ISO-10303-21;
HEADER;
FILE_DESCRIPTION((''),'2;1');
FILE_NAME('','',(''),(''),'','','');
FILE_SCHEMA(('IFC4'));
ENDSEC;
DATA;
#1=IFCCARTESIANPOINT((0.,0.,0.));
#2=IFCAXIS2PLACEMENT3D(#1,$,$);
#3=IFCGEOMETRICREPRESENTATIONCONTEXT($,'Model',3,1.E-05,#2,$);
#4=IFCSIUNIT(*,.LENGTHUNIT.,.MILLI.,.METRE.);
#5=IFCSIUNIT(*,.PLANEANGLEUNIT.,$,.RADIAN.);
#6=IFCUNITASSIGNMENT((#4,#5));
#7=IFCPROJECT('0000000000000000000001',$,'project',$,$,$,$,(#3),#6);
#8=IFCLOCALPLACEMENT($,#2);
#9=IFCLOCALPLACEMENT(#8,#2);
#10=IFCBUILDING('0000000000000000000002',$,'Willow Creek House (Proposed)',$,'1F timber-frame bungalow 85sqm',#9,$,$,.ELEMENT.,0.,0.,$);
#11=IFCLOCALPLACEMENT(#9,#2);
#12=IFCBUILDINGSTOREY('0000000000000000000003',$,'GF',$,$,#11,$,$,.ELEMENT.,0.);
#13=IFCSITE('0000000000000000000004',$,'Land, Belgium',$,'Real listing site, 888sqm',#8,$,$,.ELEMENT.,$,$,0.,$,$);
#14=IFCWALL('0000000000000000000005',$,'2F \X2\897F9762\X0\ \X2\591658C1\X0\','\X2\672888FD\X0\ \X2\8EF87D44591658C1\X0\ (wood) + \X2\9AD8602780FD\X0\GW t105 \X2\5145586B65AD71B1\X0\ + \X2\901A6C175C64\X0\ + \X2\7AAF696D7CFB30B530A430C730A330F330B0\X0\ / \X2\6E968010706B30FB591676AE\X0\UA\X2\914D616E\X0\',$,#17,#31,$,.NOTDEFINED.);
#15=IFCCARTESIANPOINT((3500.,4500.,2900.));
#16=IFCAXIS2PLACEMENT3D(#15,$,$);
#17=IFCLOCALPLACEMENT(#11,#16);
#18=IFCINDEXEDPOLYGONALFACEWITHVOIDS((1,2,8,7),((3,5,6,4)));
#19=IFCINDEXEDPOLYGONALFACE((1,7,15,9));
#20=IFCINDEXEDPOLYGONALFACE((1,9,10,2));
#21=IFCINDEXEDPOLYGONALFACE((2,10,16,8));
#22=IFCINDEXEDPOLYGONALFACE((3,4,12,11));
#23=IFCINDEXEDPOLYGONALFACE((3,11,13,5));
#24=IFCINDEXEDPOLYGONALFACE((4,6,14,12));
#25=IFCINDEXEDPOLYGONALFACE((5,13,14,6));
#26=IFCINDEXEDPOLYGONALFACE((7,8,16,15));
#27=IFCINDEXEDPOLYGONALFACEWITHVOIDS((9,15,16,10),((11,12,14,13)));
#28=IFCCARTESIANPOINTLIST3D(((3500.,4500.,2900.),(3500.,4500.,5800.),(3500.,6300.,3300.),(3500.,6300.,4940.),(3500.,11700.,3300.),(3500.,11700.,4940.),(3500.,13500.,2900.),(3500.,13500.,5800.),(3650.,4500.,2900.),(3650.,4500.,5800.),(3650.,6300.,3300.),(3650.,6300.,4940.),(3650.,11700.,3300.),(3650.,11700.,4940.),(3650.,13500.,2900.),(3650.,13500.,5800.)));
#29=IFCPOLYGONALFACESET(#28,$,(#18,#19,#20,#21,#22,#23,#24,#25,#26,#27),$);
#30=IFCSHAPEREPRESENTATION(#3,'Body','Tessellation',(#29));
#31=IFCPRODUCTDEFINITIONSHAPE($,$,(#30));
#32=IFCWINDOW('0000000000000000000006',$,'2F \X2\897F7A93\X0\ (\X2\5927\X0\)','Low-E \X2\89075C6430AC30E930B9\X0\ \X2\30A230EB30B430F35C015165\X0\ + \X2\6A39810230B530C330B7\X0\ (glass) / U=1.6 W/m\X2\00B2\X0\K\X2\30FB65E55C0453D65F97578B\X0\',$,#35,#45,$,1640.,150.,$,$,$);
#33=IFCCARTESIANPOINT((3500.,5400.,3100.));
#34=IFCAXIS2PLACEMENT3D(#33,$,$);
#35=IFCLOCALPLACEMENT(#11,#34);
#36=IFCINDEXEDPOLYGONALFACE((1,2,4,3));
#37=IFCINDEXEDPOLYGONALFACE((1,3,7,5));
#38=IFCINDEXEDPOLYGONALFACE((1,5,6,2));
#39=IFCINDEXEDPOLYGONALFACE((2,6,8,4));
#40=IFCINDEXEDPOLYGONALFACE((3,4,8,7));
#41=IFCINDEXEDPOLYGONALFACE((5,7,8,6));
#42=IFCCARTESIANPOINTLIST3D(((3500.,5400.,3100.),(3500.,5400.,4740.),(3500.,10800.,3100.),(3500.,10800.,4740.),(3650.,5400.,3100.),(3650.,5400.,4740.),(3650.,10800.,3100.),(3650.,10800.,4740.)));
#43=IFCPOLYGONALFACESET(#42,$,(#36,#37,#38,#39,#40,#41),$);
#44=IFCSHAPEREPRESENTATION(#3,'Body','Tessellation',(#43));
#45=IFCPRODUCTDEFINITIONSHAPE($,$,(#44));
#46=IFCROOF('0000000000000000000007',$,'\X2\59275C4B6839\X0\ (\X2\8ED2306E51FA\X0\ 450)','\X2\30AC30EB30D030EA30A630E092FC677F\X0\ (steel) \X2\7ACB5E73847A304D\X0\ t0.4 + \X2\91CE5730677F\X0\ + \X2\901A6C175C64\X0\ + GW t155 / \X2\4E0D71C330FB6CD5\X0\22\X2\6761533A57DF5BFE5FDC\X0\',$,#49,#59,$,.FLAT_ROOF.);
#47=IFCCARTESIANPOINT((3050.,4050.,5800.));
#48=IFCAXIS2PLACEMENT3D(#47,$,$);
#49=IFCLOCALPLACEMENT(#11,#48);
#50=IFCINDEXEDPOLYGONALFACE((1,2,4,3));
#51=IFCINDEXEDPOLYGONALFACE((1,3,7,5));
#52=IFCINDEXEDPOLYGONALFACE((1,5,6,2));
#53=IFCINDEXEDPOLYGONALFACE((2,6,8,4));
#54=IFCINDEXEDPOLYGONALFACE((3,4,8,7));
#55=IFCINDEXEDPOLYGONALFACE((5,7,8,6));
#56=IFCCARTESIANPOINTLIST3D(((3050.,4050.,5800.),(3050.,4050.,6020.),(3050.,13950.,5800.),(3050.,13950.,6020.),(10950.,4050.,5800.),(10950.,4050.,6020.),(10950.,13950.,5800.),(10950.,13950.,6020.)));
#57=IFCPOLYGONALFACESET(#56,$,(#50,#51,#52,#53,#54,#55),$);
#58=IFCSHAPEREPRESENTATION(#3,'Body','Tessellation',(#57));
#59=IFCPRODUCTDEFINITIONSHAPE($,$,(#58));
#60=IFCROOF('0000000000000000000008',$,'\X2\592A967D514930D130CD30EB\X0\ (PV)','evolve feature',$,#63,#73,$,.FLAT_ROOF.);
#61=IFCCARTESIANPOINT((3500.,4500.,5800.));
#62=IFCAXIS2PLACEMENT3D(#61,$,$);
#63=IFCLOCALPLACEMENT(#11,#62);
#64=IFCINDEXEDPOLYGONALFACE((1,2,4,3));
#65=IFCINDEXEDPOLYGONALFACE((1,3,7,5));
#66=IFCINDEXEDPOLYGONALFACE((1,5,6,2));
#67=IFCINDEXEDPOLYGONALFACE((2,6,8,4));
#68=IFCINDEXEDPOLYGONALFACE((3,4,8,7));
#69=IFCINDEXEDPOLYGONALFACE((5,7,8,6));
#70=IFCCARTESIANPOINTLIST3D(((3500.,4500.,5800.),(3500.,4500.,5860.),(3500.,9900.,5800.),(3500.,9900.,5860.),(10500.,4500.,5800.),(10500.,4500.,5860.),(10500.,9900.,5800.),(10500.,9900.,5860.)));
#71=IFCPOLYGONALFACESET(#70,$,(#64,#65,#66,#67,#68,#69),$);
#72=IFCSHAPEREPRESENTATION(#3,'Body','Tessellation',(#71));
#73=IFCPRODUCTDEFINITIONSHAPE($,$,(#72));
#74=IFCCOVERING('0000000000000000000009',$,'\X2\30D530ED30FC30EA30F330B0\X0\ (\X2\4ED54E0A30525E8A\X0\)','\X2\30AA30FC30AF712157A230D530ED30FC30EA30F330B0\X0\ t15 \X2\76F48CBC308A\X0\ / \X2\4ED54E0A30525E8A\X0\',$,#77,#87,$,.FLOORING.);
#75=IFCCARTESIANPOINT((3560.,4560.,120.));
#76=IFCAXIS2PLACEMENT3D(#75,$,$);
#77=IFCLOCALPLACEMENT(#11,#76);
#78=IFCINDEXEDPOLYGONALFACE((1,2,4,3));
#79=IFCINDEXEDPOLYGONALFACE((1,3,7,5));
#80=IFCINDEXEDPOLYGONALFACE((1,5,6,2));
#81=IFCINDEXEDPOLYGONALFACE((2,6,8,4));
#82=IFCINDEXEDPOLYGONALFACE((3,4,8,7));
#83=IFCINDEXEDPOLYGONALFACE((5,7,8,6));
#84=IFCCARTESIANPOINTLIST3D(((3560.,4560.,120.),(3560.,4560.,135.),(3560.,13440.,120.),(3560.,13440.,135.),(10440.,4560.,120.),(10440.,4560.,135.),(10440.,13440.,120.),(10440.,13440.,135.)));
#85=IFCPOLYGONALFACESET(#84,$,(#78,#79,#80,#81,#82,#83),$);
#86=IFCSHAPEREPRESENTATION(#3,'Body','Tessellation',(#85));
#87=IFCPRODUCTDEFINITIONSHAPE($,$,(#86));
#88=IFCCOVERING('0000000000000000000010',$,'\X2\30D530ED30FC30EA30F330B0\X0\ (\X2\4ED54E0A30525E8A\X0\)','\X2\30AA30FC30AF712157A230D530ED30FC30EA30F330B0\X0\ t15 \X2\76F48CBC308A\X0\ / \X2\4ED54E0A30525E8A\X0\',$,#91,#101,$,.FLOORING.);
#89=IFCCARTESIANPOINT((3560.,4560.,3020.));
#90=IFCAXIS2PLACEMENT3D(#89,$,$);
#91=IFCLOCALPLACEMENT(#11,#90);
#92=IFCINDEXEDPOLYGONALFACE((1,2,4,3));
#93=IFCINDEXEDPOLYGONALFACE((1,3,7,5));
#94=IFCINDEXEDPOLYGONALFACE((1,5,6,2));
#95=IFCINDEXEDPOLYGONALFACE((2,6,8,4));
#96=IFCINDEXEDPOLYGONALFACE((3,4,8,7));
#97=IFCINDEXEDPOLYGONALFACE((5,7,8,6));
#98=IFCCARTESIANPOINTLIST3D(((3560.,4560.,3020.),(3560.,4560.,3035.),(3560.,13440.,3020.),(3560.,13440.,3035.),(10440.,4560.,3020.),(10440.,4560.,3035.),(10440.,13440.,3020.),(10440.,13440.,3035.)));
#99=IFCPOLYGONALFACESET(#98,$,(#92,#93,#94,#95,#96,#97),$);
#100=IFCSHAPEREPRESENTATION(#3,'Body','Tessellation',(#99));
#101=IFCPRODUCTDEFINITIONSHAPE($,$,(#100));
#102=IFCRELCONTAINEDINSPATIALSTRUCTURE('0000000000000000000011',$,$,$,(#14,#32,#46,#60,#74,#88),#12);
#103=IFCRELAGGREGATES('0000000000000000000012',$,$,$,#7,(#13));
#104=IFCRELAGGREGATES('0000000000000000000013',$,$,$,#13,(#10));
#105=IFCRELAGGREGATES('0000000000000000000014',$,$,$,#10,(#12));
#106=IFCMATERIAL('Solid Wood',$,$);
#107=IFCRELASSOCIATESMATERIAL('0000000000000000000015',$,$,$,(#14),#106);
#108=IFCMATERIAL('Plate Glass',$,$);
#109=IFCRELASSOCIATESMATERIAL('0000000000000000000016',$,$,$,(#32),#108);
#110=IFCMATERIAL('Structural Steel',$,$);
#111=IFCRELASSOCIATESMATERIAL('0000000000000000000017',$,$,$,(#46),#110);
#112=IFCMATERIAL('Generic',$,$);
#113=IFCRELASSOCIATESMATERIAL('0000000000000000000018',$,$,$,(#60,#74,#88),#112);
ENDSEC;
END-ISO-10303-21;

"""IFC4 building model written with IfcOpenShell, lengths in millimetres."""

from ifc_helpers import new_model, si_unit, frame, frame_2d, origin, place, context, project, spatial, rectangle, extrude, material, element, fill, save


model = new_model("IFC4")

# Units and contexts
model_context = context("Model", 3, precision=1e-05, world=origin())
ifc_project = project(units=[si_unit("LENGTHUNIT", "METRE", prefix="MILLI"), si_unit("PLANEANGLEUNIT", "RADIAN")], contexts=[model_context])

# Site, building, storey
site_placement = place(None, origin())
site = spatial("IfcSite", under=ifc_project, at=site_placement, Name="Land, Belgium", ObjectType="Real listing site, 888sqm", CompositionType="ELEMENT", RefElevation=0.0)
building_placement = place(site_placement, origin())
building = spatial("IfcBuilding", under=site, at=building_placement, Name="Willow Creek House (Proposed)", ObjectType="1F timber-frame bungalow 85sqm", CompositionType="ELEMENT", ElevationOfRefHeight=0.0, ElevationOfTerrain=0.0)
storey_placement = place(building_placement, origin())
storey = spatial("IfcBuildingStorey", under=building, at=storey_placement, Name="GF", CompositionType="ELEMENT", Elevation=0.0)

# Shared definitions
ifc_material_1 = material(Name="Solid Wood")
ifc_material_2 = material(Name="Generic")

# Shared definitions
ifc_material_3 = material(Name="Plate Glass")

# Wall, opening, window
wall_1_placement = place(storey_placement, frame((3500.0, 4500.0, 2900.0)))
wall_1 = element("IfcWall", 1, at=wall_1_placement, inside=storey, material=ifc_material_1, Name="2F 西面 外壁", Description="木製 軸組外壁 (wood) + 高性能GW t105 充填断熱 + 通気層 + 窯業系サイディング / 準耐火・外皮UA配慮", PredefinedType="NOTDEFINED", context=model_context, shape_type="SweptSolid", body=[
    extrude(rectangle(XDim=150.0, YDim=9000.0, at=frame_2d((75.0, 4500.0))), frame((3500.0, 4500.0, 2900.0)), (0.0, 0.0, 1.0), 2900.0),
])
opening_1_placement = place(storey_placement, frame((3500.0, 5400.0, 3100.0)))
opening_1 = element("IfcOpeningElement", 2, at=opening_1_placement, cuts=wall_1, PredefinedType="NOTDEFINED", context=model_context, shape_type="SweptSolid", body=[
    extrude(rectangle(XDim=150.0, YDim=5400.0, at=frame_2d((75.0, 2700.0))), frame((3500.0, 5400.0, 3100.0)), (0.0, 0.0, 1.0), 1640.0),
])
window_1_placement = place(storey_placement, frame((3500.0, 5400.0, 3100.0)))
window_1 = element("IfcWindow", 3, at=window_1_placement, inside=storey, material=ifc_material_3, Name="2F 西窓 (大)", Description="Low-E 複層ガラス アルゴン封入 + 樹脂サッシ (glass) / U=1.6 W/m²K・日射取得型", OverallHeight=1640.0, OverallWidth=150.0, context=model_context, shape_type="SweptSolid", body=[
    extrude(rectangle(XDim=150.0, YDim=5400.0, at=frame_2d((75.0, 2700.0))), frame((3500.0, 5400.0, 3100.0)), (0.0, 0.0, 1.0), 1640.0),
])
fill(opening_1, window_1)

# Roofs
ifc_material_4 = material(Name="Structural Steel")
roof_1_placement = place(storey_placement, frame((3050.0, 4050.0, 5800.0)))
element("IfcRoof", 4, at=roof_1_placement, inside=storey, material=ifc_material_4, Name="大屋根 (軒の出 450)", Description="ガルバリウム鋼板 (steel) 立平葺き t0.4 + 野地板 + 通気層 + GW t155 / 不燃・法22条区域対応", PredefinedType="FLAT_ROOF", context=model_context, shape_type="SweptSolid", body=[
    extrude(rectangle(XDim=7900.0, YDim=9900.0, at=frame_2d((3950.0, 4950.0))), frame((3050.0, 4050.0, 5800.0)), (0.0, 0.0, 1.0), 220.0),
])
roof_2_placement = place(storey_placement, frame((3500.0, 4500.0, 5800.0)))
element("IfcRoof", 5, at=roof_2_placement, inside=storey, material=ifc_material_2, Name="太陽光パネル (PV)", Description="evolve feature", PredefinedType="FLAT_ROOF", context=model_context, shape_type="SweptSolid", body=[
    extrude(rectangle(XDim=7000.0, YDim=5400.0, at=frame_2d((3500.0, 2700.0))), frame((3500.0, 4500.0, 5800.0)), (0.0, 0.0, 1.0), 60.0),
])

# Coverings
covering_1_placement = place(storey_placement, frame((3560.0, 4560.0, 120.0)))
element("IfcCovering", 6, at=covering_1_placement, inside=storey, material=ifc_material_2, Name="フローリング (仕上げ床)", Description="オーク無垢フローリング t15 直貼り / 仕上げ床", PredefinedType="FLOORING", context=model_context, shape_type="SweptSolid", body=[
    extrude(rectangle(XDim=6880.0, YDim=8880.0, at=frame_2d((3440.0, 4440.0))), frame((3560.0, 4560.0, 120.0)), (0.0, 0.0, 1.0), 15.0),
])
covering_2_placement = place(storey_placement, frame((3560.0, 4560.0, 3020.0)))
element("IfcCovering", 7, at=covering_2_placement, inside=storey, material=ifc_material_2, Name="フローリング (仕上げ床)", Description="オーク無垢フローリング t15 直貼り / 仕上げ床", PredefinedType="FLOORING", context=model_context, shape_type="SweptSolid", body=[
    extrude(rectangle(XDim=6880.0, YDim=8880.0, at=frame_2d((3440.0, 4440.0))), frame((3560.0, 4560.0, 3020.0)), (0.0, 0.0, 1.0), 15.0),
])

save(model, "model.ifc")
